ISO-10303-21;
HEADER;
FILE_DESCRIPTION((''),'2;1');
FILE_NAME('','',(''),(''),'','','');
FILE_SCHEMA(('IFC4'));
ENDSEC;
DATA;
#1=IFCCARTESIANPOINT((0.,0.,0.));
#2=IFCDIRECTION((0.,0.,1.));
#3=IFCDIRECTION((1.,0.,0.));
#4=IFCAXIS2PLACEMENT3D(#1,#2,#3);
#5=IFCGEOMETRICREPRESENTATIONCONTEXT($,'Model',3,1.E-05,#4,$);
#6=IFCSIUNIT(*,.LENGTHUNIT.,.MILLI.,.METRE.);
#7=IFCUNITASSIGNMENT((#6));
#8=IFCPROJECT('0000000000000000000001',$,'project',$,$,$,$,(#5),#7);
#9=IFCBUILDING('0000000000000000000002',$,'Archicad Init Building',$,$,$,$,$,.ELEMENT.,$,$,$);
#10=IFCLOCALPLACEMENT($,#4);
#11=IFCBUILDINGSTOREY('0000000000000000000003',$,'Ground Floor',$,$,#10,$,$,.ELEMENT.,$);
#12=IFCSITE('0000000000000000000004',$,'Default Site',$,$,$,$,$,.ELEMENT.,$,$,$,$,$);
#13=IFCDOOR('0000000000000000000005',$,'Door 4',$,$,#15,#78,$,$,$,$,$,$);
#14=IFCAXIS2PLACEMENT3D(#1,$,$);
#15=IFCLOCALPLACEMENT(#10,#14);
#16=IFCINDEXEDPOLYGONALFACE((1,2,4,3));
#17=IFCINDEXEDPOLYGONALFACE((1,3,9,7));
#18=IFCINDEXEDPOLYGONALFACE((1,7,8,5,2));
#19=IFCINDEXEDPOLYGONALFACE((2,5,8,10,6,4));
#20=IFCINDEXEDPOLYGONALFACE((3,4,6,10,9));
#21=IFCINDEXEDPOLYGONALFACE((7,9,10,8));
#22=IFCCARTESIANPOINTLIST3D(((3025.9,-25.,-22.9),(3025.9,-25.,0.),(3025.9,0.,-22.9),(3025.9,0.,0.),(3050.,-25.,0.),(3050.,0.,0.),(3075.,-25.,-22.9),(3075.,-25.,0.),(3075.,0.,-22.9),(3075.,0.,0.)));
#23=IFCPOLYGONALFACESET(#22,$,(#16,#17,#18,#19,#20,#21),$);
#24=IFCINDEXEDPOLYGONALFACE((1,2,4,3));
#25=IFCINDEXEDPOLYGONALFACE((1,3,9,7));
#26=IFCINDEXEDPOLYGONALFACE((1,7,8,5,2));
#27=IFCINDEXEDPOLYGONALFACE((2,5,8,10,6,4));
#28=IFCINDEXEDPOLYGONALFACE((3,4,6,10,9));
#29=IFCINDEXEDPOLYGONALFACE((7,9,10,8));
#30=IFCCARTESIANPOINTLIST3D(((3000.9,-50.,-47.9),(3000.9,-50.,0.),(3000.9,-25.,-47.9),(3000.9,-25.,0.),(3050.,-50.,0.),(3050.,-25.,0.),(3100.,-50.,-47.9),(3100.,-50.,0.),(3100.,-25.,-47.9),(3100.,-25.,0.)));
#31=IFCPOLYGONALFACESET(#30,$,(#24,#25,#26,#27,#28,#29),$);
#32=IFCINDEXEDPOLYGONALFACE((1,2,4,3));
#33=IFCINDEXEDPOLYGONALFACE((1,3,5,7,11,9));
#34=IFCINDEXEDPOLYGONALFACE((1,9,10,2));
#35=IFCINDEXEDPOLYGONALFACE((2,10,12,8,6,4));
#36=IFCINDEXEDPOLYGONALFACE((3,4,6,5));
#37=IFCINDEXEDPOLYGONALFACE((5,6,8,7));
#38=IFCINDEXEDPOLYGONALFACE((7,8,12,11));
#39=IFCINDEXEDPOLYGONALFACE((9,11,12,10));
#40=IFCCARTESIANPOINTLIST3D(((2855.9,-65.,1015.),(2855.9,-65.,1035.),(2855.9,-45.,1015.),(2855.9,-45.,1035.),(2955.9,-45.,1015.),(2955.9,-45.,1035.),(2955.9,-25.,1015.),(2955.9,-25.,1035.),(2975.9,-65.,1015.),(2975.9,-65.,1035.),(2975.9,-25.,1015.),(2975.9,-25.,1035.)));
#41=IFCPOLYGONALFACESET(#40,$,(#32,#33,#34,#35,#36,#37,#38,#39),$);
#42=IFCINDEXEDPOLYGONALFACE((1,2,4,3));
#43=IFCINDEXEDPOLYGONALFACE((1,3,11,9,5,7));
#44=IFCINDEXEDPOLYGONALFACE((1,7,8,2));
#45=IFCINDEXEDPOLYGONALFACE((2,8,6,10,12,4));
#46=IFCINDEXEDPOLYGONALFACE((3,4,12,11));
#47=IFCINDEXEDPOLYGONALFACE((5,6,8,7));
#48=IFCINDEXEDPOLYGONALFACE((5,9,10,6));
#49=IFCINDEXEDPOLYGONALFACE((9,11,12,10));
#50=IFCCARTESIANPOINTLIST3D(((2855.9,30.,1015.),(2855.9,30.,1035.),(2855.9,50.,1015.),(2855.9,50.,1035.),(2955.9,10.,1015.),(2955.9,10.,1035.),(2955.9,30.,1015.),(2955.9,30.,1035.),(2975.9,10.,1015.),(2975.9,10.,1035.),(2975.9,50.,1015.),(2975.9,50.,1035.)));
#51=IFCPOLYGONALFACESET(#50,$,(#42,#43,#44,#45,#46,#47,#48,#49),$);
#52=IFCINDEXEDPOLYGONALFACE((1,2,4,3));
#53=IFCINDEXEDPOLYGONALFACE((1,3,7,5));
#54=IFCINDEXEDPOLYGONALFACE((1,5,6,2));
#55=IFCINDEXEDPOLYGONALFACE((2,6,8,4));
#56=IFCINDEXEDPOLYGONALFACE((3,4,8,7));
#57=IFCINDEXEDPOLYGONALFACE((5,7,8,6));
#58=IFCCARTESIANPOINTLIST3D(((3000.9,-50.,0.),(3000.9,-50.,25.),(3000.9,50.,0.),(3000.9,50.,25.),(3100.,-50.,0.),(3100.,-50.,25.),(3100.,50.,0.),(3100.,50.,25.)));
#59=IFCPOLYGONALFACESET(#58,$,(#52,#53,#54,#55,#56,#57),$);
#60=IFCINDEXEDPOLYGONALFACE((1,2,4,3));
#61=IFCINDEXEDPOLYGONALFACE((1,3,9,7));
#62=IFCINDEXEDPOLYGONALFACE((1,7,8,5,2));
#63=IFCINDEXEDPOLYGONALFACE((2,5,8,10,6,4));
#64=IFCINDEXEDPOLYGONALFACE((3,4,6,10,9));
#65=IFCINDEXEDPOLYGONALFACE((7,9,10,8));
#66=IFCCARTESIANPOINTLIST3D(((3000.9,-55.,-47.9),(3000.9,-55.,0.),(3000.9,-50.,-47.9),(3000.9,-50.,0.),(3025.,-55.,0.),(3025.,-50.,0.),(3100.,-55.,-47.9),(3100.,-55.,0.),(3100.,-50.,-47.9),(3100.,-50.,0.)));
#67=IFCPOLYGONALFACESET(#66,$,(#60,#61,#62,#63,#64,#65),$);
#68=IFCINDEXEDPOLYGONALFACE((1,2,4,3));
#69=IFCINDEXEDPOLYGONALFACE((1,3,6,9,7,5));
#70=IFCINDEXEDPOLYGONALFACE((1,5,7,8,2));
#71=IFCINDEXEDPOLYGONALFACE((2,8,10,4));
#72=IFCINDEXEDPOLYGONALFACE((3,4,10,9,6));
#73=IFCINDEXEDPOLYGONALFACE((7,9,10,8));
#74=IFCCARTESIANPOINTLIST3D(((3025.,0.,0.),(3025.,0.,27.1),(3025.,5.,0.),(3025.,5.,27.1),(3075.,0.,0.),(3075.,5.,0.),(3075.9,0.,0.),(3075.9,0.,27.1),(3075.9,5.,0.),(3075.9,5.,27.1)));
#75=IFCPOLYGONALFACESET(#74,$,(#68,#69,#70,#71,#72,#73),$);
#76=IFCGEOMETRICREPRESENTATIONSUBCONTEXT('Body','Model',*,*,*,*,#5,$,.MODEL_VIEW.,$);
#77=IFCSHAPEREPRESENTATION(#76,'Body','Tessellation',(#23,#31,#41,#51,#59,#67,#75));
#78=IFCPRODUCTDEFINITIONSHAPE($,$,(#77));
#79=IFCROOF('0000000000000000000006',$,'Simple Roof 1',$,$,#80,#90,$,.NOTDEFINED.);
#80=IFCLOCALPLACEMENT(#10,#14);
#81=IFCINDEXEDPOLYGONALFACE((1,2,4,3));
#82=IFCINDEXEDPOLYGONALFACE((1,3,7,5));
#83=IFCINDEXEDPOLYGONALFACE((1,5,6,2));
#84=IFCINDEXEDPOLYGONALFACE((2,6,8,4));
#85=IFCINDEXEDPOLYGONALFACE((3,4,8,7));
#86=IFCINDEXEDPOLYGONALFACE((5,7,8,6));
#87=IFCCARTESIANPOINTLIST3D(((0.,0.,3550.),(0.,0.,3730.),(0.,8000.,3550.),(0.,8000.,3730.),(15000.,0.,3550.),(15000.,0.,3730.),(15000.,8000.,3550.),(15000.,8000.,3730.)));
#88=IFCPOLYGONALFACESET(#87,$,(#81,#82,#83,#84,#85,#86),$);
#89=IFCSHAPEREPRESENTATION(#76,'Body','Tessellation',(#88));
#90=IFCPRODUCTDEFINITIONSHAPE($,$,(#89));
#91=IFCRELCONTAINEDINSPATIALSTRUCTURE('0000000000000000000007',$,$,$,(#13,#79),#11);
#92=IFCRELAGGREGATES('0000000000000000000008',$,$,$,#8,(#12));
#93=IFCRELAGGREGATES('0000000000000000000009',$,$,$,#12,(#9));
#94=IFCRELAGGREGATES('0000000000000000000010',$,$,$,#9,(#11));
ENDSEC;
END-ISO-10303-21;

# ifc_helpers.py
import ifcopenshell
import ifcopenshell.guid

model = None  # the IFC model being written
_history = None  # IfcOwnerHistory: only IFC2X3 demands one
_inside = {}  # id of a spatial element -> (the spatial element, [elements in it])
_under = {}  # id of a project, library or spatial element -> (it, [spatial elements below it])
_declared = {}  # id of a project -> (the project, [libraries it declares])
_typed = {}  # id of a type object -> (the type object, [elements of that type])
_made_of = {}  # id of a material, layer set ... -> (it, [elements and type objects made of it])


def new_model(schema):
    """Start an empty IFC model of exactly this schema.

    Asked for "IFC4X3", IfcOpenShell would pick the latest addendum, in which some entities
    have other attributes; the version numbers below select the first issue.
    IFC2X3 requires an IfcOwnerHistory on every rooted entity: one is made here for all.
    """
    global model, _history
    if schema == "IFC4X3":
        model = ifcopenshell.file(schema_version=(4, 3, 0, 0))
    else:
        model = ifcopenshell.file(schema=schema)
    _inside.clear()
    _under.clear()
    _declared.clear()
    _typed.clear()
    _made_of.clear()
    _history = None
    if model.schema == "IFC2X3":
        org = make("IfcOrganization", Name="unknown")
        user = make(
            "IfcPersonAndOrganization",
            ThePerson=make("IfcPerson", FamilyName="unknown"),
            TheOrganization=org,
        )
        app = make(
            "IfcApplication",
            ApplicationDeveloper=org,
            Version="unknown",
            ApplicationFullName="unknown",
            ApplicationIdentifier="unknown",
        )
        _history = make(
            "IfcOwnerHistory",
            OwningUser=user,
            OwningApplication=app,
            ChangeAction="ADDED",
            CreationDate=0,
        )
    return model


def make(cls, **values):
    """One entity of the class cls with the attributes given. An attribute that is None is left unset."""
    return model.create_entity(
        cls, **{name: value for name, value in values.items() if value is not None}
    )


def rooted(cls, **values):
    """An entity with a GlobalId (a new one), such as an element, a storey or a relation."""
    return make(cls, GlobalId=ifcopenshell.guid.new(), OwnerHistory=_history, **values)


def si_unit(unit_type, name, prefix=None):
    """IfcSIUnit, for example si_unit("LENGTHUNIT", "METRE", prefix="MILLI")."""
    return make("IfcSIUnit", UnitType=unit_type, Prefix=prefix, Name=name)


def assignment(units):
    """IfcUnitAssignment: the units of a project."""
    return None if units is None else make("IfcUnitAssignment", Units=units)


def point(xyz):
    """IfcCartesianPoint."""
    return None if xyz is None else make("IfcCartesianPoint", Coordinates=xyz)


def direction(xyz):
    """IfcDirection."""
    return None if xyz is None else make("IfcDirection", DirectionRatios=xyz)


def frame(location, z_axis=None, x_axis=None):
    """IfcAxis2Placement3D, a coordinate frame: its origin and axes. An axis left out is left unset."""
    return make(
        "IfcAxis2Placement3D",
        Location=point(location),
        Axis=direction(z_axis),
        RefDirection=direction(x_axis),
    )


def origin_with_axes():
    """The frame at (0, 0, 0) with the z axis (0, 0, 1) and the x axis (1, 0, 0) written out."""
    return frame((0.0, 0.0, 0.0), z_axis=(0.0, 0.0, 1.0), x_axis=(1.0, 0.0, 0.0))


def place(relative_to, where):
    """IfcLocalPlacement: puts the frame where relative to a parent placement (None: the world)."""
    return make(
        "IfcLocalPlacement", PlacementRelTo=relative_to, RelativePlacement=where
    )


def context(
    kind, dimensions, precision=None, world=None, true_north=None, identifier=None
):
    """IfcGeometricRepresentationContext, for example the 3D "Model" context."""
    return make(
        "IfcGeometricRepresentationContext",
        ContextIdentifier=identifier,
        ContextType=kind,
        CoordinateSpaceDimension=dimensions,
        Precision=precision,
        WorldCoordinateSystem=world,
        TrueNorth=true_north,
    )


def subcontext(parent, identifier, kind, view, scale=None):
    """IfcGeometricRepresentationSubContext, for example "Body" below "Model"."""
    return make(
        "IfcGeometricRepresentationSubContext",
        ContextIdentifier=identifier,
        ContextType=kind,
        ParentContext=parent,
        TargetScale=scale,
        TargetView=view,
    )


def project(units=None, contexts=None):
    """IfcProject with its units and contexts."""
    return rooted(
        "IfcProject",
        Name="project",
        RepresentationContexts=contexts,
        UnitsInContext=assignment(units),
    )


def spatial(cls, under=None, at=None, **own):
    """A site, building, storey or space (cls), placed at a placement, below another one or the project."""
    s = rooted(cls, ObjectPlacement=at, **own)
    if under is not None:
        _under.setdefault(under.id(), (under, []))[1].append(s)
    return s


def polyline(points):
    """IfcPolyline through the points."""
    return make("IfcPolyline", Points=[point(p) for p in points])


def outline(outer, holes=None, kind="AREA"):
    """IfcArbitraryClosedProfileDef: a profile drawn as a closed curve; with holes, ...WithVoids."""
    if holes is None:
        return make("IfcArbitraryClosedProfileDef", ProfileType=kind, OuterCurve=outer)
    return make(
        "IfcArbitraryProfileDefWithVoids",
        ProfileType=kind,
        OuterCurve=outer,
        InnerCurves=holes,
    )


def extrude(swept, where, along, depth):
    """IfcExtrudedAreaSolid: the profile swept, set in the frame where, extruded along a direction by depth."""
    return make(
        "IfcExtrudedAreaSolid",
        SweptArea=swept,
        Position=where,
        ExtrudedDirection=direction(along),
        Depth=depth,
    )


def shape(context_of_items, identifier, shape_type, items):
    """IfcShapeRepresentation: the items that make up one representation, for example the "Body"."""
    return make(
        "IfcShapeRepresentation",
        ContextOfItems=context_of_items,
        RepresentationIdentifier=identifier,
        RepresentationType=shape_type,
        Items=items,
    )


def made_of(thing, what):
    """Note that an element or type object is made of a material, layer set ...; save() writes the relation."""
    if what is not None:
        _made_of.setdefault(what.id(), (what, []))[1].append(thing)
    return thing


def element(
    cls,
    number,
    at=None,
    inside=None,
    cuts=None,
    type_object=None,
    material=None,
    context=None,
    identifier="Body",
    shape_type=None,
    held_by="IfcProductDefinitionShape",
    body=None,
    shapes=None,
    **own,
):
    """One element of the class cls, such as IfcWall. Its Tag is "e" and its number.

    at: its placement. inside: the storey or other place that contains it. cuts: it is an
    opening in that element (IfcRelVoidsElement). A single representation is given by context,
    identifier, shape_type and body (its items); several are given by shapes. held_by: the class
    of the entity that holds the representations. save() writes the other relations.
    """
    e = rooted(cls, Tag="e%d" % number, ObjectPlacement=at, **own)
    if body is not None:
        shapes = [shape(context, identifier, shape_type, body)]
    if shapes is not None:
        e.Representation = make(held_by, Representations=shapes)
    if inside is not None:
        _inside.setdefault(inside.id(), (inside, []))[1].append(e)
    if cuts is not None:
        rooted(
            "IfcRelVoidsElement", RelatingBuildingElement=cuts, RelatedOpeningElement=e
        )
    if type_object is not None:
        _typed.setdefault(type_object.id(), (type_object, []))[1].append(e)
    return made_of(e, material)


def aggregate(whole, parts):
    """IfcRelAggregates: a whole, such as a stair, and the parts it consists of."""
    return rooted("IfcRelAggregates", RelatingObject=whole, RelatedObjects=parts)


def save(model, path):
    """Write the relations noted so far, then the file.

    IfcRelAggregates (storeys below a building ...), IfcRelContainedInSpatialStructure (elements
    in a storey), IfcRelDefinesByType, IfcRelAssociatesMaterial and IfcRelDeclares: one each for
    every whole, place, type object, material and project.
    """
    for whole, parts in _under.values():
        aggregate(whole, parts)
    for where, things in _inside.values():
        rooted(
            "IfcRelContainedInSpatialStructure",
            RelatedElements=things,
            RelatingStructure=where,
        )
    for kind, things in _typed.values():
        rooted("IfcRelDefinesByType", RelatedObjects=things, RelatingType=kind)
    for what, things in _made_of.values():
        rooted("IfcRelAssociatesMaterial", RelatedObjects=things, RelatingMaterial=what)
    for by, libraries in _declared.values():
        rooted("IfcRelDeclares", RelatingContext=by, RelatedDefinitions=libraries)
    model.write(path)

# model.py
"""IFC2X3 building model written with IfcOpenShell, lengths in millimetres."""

from ifc_helpers import new_model, si_unit, frame, origin_with_axes, place, context, subcontext, project, spatial, polyline, outline, extrude, element, save


model = new_model("IFC2X3")

# Units and contexts
model_context = context("Model", 3, precision=1e-05, world=origin_with_axes())
body_context = subcontext(model_context, "Body", "Model", "MODEL_VIEW")
ifc_project = project(units=[si_unit("LENGTHUNIT", "METRE", prefix="MILLI")], contexts=[model_context])

# Site, building, storey
site = spatial("IfcSite", under=ifc_project, Name="Default Site", CompositionType="ELEMENT")
building = spatial("IfcBuilding", under=site, Name="Archicad Init Building", CompositionType="ELEMENT")
storey_placement = place(None, origin_with_axes())
storey = spatial("IfcBuildingStorey", under=building, at=storey_placement, Name="Ground Floor", CompositionType="ELEMENT")

# Door
door_1_placement = place(storey_placement, frame((3050.0, -50.0, 0.0), z_axis=(0.0, 0.0, 1.0), x_axis=(1.0, 0.0, 0.0)))
element("IfcDoor", 1, at=door_1_placement, inside=storey, Name="Door 4", context=body_context, shape_type="SweptSolid", body=[
    extrude(outline(polyline([(0.0, 0.0), (0.0, 2.1), (0.9, 2.1), (0.9, 0.0), (-24.1, 0.0), (-24.1, -22.9), (25.0, -22.9), (25.0, 0.0), (0.0, 0.0)])), frame((0.0, 25.0, 0.0), z_axis=(0.0, -1.0, 0.0), x_axis=(1.0, 0.0, 0.0)), (0.0, 0.0, -1.0), 25.0),
    extrude(outline(polyline([(0.0, 0.0), (0.0, 2.1), (0.9, 2.1), (0.9, 0.0), (-49.1, 0.0), (-49.1, -47.9), (50.0, -47.9), (50.0, 0.0), (0.0, 0.0)])), frame((0.0, 0.0, 0.0), z_axis=(0.0, -1.0, 0.0), x_axis=(1.0, 0.0, 0.0)), (0.0, 0.0, -1.0), 25.0),
    extrude(outline(polyline([(0.0, 0.0), (-49.1, 0.0), (-49.1, 35.0), (0.0, 35.0), (0.0, 0.0)])), frame((25.0, 25.0, 25.0), z_axis=(0.0, 0.0, 1.0), x_axis=(1.0, 0.0, 0.0)), (0.0, 0.0, 1.0), -47.9),
    extrude(outline(polyline([(0.0, 0.0), (0.0, -40.0), (-120.0, -40.0), (-120.0, -20.0), (-20.0, -20.0), (-20.0, 0.0), (0.0, 0.0)])), frame((-74.1, 25.0, 1015.0), z_axis=(0.0, 0.0, 1.0), x_axis=(1.0, 0.0, 0.0)), (0.0, 0.0, 1.0), 20.0),
    extrude(outline(polyline([(0.0, 0.0), (0.0, 40.0), (-120.0, 40.0), (-120.0, 20.0), (-20.0, 20.0), (-20.0, 0.0), (0.0, 0.0)])), frame((-74.1, 60.0, 1015.0), z_axis=(0.0, 0.0, 1.0), x_axis=(1.0, 0.0, 0.0)), (0.0, 0.0, 1.0), 20.0),
    extrude(outline(polyline([(0.0, 0.0), (-99.1, 0.0), (-99.1, 100.0), (0.0, 100.0), (0.0, 0.0)])), frame((50.0, 0.0, 0.0), z_axis=(0.0, 0.0, 1.0), x_axis=(1.0, 0.0, 0.0)), (0.0, 0.0, 1.0), 25.0),
    extrude(outline(polyline([(0.0, 0.0), (0.0, 27.1), (50.9, 27.1), (50.9, 0.0), (-24.1, 0.0), (-24.1, -47.9), (75.0, -47.9), (75.0, 0.0), (0.0, 0.0)])), frame((-25.0, -5.0, 0.0), z_axis=(0.0, -1.0, 0.0), x_axis=(1.0, 0.0, 0.0)), (0.0, 0.0, -1.0), 5.0),
    extrude(outline(polyline([(0.0, 0.0), (0.0, 27.1), (50.9, 27.1), (50.9, 0.0), (0.9, 0.0), (0.9, -22.9), (50.0, -22.9), (50.0, 0.0), (0.0, 0.0)])), frame((-25.0, 50.0, 0.0), z_axis=(0.0, -1.0, 0.0), x_axis=(1.0, 0.0, 0.0)), (0.0, 0.0, -1.0), 5.0),
])

# Roof
roof_placement = place(storey_placement, frame((0.0, 0.0, 3550.0), z_axis=(0.0, 0.0, 1.0), x_axis=(1.0, 0.0, 0.0)))
element("IfcRoof", 2, at=roof_placement, inside=storey, Name="Simple Roof 1", ShapeType="NOTDEFINED", context=body_context, shape_type="SweptSolid", body=[
    extrude(outline(polyline([(0.0, 0.0), (15000.0, 0.0), (15000.0, 8000.0), (0.0, 8000.0), (0.0, 0.0)])), origin_with_axes(), (0.0, 0.0, 1.0), 180.0),
])

save(model, "model.ifc")
